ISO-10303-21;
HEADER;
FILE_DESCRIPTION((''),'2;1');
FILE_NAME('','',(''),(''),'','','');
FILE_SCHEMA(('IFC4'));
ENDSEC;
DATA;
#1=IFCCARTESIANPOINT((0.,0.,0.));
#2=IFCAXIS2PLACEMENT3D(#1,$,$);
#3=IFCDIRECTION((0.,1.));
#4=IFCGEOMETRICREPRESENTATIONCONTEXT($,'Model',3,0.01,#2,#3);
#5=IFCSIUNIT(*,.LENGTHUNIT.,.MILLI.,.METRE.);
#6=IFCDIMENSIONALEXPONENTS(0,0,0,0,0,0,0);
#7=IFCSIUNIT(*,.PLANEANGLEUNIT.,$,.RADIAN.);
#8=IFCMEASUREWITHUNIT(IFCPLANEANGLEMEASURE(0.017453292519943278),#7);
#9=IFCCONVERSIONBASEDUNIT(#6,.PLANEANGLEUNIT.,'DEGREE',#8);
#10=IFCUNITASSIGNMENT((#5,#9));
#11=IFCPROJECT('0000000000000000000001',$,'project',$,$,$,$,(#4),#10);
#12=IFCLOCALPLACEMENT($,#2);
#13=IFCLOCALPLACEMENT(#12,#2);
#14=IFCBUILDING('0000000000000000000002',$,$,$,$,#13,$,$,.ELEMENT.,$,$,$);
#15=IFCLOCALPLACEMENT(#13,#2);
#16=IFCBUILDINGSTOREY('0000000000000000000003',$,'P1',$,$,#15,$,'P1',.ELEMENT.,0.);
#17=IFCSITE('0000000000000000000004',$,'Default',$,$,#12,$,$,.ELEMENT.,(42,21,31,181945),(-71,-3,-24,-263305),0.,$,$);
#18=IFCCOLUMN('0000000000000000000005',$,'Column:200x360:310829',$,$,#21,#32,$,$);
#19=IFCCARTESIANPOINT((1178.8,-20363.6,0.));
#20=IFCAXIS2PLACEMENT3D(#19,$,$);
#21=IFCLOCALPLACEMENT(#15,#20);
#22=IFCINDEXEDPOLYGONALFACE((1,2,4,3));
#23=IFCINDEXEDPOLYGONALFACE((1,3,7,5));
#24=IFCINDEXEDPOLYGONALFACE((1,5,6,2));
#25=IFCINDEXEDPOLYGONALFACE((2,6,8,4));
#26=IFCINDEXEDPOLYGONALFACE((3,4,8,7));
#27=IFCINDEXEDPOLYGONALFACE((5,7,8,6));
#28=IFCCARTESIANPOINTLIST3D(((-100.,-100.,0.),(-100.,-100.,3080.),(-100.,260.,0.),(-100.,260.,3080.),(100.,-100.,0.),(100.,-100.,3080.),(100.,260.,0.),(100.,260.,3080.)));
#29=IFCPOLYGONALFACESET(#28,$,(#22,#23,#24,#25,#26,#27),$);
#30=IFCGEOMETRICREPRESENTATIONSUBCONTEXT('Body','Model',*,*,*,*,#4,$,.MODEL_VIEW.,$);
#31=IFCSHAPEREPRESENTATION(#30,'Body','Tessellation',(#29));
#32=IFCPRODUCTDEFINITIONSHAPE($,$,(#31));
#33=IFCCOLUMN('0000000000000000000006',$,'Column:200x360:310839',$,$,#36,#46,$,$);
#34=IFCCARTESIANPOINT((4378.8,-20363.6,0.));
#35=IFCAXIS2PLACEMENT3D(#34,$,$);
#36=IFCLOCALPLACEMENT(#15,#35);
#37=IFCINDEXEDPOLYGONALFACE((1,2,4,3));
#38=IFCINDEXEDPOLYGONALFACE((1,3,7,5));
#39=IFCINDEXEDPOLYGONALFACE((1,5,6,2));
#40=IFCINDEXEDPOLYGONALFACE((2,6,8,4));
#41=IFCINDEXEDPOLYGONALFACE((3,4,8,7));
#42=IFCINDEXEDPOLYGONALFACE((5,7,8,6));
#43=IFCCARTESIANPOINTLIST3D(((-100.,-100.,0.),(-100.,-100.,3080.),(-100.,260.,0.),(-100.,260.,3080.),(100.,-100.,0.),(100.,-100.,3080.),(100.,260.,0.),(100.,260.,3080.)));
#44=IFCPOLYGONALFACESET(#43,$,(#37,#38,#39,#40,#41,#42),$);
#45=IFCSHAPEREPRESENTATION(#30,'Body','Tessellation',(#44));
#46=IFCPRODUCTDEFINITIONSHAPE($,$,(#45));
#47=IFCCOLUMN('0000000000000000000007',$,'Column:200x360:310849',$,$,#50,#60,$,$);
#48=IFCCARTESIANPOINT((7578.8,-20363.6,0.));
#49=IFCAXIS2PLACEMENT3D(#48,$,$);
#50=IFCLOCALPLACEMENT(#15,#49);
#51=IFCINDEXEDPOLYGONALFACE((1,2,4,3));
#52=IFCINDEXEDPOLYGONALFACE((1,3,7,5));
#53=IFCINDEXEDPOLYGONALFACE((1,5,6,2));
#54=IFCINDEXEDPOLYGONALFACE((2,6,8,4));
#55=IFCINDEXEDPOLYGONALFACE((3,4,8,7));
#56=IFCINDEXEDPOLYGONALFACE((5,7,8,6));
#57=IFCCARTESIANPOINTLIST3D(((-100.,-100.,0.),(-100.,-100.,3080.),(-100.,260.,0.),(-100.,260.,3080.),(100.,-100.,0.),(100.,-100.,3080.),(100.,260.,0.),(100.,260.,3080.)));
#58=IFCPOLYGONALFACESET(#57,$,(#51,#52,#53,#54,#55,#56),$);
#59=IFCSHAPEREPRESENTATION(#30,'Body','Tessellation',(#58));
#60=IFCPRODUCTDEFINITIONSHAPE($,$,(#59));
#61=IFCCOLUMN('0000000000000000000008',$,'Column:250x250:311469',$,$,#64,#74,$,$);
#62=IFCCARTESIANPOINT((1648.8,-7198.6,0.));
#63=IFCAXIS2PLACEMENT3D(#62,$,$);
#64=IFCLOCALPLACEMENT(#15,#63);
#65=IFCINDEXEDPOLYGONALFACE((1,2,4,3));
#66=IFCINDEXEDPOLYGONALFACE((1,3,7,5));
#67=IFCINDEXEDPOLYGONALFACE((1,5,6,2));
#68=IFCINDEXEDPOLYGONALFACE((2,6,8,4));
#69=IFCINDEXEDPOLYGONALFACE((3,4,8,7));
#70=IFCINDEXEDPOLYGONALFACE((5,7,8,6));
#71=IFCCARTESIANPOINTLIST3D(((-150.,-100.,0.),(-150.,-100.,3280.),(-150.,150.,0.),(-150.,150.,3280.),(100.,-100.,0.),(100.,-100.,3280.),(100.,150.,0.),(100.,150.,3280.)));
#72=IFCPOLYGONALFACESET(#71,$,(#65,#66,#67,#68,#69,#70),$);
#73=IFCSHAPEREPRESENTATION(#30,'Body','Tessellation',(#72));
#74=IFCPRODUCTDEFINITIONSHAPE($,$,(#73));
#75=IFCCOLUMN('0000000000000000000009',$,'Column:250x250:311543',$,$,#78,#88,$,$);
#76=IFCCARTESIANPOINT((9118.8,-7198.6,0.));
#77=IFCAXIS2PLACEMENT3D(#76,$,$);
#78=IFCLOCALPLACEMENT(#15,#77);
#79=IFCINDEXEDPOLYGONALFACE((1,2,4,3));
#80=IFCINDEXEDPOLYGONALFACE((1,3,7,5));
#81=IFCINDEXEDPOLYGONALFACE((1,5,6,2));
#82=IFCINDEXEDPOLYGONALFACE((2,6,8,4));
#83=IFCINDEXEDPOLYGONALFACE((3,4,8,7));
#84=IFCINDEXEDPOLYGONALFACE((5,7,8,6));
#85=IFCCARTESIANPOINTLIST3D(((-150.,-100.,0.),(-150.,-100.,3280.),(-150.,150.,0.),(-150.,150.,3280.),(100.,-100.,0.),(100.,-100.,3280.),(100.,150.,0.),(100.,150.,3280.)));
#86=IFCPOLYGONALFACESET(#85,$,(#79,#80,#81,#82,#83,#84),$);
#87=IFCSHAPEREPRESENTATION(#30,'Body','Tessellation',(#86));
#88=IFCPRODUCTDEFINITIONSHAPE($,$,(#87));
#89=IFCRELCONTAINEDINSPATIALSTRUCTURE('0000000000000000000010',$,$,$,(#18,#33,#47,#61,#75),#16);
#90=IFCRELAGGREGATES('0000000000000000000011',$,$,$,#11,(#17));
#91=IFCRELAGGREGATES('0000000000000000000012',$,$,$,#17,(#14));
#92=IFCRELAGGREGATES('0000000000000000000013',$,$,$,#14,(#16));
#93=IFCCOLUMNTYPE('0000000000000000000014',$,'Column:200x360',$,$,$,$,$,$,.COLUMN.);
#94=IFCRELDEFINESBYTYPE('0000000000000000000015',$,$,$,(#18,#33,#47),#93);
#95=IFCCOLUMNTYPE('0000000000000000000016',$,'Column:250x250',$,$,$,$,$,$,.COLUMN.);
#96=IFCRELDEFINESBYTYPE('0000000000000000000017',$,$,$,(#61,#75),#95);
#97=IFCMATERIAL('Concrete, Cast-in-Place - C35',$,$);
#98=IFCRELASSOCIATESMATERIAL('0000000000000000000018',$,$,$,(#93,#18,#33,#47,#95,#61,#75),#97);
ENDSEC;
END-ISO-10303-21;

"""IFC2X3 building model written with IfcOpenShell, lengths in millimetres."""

from ifc_helpers import new_model, entity, si_unit, converted_unit, direction, frame, origin, origin_2d_with_axis, place, context, subcontext, project, spatial, rectangle, extrude, source, transform, mapped, material, type_object, type_shapes, element, save


model = new_model("IFC2X3")

# Units and contexts
model_context = context("Model", 3, precision=0.01, world=origin(), true_north=direction((0.0, 1.0)))
body_context = subcontext(model_context, "Body", "Model", "MODEL_VIEW")
ifc_project = project(units=[si_unit("LENGTHUNIT", "METRE", prefix="MILLI"), converted_unit("PLANEANGLEUNIT", "DEGREE", entity("IfcPlaneAngleMeasure", 0.017453292519943278), si_unit("PLANEANGLEUNIT", "RADIAN"), dimensions=[0, 0, 0, 0, 0, 0, 0])], contexts=[model_context])

# Site, building, storey
site_placement = place(None, origin())
site = spatial("IfcSite", under=ifc_project, at=site_placement, Name="Default", CompositionType="ELEMENT", RefLatitude=(42, 21, 31, 181945), RefLongitude=(-71, -3, -24, -263305), RefElevation=0.0)
building_placement = place(site_placement, origin())
building = spatial("IfcBuilding", under=site, at=building_placement, CompositionType="ELEMENT")
storey_placement = place(building_placement, origin())
storey = spatial("IfcBuildingStorey", under=building, at=storey_placement, Name="P1", LongName="P1", CompositionType="ELEMENT", Elevation=0.0)

# Columns
ifc_material_1 = material(Name="Concrete, Cast-in-Place - C35")
column_type_1 = type_object("IfcColumnType", Name="Column:200x360", PredefinedType="COLUMN", material=ifc_material_1)
shared_shape_1 = source(origin(), body_context, "Body", "SweptSolid", [
    extrude(rectangle(XDim=200.0, YDim=360.0, at=origin_2d_with_axis()), frame((0.0, 80.0, 0.0), z_axis=(0.0, 0.0, 1.0), x_axis=(-1.0, 0.0, 0.0)), (0.0, 0.0, 1.0), 3080.0),
])
type_shapes(column_type_1, [shared_shape_1])
for number, where, name in (
    (1, (1178.8, -20363.6, 0.0), "Column:200x360:310829"),
    (2, (4378.8, -20363.6, 0.0), "Column:200x360:310839"),
    (3, (7578.8, -20363.6, 0.0), "Column:200x360:310849"),
):
    element("IfcColumn", number, at=place(storey_placement, frame(where)), inside=storey, type_object=column_type_1, material=ifc_material_1, Name=name, context=body_context, shape_type="MappedRepresentation", body=[
        mapped(shared_shape_1, transform((0.0, 0.0, 0.0), scale=1.0)),
    ])
column_type_2 = type_object("IfcColumnType", Name="Column:250x250", PredefinedType="COLUMN", material=ifc_material_1)
shared_shape_2 = source(origin(), body_context, "Body", "SweptSolid", [
    extrude(rectangle(XDim=250.0, YDim=250.0, at=origin_2d_with_axis()), frame((-25.0, 25.0, 0.0), z_axis=(0.0, 0.0, 1.0), x_axis=(-1.0, 0.0, 0.0)), (0.0, 0.0, 1.0), 3280.0),
])
type_shapes(column_type_2, [shared_shape_2])
for number, where, name in (
    (4, (1648.8, -7198.6, 0.0), "Column:250x250:311469"),
    (5, (9118.8, -7198.6, 0.0), "Column:250x250:311543"),
):
    element("IfcColumn", number, at=place(storey_placement, frame(where)), inside=storey, type_object=column_type_2, material=ifc_material_1, Name=name, context=body_context, shape_type="MappedRepresentation", body=[
        mapped(shared_shape_2, transform((0.0, 0.0, 0.0), scale=1.0)),
    ])

save(model, "model.ifc")
